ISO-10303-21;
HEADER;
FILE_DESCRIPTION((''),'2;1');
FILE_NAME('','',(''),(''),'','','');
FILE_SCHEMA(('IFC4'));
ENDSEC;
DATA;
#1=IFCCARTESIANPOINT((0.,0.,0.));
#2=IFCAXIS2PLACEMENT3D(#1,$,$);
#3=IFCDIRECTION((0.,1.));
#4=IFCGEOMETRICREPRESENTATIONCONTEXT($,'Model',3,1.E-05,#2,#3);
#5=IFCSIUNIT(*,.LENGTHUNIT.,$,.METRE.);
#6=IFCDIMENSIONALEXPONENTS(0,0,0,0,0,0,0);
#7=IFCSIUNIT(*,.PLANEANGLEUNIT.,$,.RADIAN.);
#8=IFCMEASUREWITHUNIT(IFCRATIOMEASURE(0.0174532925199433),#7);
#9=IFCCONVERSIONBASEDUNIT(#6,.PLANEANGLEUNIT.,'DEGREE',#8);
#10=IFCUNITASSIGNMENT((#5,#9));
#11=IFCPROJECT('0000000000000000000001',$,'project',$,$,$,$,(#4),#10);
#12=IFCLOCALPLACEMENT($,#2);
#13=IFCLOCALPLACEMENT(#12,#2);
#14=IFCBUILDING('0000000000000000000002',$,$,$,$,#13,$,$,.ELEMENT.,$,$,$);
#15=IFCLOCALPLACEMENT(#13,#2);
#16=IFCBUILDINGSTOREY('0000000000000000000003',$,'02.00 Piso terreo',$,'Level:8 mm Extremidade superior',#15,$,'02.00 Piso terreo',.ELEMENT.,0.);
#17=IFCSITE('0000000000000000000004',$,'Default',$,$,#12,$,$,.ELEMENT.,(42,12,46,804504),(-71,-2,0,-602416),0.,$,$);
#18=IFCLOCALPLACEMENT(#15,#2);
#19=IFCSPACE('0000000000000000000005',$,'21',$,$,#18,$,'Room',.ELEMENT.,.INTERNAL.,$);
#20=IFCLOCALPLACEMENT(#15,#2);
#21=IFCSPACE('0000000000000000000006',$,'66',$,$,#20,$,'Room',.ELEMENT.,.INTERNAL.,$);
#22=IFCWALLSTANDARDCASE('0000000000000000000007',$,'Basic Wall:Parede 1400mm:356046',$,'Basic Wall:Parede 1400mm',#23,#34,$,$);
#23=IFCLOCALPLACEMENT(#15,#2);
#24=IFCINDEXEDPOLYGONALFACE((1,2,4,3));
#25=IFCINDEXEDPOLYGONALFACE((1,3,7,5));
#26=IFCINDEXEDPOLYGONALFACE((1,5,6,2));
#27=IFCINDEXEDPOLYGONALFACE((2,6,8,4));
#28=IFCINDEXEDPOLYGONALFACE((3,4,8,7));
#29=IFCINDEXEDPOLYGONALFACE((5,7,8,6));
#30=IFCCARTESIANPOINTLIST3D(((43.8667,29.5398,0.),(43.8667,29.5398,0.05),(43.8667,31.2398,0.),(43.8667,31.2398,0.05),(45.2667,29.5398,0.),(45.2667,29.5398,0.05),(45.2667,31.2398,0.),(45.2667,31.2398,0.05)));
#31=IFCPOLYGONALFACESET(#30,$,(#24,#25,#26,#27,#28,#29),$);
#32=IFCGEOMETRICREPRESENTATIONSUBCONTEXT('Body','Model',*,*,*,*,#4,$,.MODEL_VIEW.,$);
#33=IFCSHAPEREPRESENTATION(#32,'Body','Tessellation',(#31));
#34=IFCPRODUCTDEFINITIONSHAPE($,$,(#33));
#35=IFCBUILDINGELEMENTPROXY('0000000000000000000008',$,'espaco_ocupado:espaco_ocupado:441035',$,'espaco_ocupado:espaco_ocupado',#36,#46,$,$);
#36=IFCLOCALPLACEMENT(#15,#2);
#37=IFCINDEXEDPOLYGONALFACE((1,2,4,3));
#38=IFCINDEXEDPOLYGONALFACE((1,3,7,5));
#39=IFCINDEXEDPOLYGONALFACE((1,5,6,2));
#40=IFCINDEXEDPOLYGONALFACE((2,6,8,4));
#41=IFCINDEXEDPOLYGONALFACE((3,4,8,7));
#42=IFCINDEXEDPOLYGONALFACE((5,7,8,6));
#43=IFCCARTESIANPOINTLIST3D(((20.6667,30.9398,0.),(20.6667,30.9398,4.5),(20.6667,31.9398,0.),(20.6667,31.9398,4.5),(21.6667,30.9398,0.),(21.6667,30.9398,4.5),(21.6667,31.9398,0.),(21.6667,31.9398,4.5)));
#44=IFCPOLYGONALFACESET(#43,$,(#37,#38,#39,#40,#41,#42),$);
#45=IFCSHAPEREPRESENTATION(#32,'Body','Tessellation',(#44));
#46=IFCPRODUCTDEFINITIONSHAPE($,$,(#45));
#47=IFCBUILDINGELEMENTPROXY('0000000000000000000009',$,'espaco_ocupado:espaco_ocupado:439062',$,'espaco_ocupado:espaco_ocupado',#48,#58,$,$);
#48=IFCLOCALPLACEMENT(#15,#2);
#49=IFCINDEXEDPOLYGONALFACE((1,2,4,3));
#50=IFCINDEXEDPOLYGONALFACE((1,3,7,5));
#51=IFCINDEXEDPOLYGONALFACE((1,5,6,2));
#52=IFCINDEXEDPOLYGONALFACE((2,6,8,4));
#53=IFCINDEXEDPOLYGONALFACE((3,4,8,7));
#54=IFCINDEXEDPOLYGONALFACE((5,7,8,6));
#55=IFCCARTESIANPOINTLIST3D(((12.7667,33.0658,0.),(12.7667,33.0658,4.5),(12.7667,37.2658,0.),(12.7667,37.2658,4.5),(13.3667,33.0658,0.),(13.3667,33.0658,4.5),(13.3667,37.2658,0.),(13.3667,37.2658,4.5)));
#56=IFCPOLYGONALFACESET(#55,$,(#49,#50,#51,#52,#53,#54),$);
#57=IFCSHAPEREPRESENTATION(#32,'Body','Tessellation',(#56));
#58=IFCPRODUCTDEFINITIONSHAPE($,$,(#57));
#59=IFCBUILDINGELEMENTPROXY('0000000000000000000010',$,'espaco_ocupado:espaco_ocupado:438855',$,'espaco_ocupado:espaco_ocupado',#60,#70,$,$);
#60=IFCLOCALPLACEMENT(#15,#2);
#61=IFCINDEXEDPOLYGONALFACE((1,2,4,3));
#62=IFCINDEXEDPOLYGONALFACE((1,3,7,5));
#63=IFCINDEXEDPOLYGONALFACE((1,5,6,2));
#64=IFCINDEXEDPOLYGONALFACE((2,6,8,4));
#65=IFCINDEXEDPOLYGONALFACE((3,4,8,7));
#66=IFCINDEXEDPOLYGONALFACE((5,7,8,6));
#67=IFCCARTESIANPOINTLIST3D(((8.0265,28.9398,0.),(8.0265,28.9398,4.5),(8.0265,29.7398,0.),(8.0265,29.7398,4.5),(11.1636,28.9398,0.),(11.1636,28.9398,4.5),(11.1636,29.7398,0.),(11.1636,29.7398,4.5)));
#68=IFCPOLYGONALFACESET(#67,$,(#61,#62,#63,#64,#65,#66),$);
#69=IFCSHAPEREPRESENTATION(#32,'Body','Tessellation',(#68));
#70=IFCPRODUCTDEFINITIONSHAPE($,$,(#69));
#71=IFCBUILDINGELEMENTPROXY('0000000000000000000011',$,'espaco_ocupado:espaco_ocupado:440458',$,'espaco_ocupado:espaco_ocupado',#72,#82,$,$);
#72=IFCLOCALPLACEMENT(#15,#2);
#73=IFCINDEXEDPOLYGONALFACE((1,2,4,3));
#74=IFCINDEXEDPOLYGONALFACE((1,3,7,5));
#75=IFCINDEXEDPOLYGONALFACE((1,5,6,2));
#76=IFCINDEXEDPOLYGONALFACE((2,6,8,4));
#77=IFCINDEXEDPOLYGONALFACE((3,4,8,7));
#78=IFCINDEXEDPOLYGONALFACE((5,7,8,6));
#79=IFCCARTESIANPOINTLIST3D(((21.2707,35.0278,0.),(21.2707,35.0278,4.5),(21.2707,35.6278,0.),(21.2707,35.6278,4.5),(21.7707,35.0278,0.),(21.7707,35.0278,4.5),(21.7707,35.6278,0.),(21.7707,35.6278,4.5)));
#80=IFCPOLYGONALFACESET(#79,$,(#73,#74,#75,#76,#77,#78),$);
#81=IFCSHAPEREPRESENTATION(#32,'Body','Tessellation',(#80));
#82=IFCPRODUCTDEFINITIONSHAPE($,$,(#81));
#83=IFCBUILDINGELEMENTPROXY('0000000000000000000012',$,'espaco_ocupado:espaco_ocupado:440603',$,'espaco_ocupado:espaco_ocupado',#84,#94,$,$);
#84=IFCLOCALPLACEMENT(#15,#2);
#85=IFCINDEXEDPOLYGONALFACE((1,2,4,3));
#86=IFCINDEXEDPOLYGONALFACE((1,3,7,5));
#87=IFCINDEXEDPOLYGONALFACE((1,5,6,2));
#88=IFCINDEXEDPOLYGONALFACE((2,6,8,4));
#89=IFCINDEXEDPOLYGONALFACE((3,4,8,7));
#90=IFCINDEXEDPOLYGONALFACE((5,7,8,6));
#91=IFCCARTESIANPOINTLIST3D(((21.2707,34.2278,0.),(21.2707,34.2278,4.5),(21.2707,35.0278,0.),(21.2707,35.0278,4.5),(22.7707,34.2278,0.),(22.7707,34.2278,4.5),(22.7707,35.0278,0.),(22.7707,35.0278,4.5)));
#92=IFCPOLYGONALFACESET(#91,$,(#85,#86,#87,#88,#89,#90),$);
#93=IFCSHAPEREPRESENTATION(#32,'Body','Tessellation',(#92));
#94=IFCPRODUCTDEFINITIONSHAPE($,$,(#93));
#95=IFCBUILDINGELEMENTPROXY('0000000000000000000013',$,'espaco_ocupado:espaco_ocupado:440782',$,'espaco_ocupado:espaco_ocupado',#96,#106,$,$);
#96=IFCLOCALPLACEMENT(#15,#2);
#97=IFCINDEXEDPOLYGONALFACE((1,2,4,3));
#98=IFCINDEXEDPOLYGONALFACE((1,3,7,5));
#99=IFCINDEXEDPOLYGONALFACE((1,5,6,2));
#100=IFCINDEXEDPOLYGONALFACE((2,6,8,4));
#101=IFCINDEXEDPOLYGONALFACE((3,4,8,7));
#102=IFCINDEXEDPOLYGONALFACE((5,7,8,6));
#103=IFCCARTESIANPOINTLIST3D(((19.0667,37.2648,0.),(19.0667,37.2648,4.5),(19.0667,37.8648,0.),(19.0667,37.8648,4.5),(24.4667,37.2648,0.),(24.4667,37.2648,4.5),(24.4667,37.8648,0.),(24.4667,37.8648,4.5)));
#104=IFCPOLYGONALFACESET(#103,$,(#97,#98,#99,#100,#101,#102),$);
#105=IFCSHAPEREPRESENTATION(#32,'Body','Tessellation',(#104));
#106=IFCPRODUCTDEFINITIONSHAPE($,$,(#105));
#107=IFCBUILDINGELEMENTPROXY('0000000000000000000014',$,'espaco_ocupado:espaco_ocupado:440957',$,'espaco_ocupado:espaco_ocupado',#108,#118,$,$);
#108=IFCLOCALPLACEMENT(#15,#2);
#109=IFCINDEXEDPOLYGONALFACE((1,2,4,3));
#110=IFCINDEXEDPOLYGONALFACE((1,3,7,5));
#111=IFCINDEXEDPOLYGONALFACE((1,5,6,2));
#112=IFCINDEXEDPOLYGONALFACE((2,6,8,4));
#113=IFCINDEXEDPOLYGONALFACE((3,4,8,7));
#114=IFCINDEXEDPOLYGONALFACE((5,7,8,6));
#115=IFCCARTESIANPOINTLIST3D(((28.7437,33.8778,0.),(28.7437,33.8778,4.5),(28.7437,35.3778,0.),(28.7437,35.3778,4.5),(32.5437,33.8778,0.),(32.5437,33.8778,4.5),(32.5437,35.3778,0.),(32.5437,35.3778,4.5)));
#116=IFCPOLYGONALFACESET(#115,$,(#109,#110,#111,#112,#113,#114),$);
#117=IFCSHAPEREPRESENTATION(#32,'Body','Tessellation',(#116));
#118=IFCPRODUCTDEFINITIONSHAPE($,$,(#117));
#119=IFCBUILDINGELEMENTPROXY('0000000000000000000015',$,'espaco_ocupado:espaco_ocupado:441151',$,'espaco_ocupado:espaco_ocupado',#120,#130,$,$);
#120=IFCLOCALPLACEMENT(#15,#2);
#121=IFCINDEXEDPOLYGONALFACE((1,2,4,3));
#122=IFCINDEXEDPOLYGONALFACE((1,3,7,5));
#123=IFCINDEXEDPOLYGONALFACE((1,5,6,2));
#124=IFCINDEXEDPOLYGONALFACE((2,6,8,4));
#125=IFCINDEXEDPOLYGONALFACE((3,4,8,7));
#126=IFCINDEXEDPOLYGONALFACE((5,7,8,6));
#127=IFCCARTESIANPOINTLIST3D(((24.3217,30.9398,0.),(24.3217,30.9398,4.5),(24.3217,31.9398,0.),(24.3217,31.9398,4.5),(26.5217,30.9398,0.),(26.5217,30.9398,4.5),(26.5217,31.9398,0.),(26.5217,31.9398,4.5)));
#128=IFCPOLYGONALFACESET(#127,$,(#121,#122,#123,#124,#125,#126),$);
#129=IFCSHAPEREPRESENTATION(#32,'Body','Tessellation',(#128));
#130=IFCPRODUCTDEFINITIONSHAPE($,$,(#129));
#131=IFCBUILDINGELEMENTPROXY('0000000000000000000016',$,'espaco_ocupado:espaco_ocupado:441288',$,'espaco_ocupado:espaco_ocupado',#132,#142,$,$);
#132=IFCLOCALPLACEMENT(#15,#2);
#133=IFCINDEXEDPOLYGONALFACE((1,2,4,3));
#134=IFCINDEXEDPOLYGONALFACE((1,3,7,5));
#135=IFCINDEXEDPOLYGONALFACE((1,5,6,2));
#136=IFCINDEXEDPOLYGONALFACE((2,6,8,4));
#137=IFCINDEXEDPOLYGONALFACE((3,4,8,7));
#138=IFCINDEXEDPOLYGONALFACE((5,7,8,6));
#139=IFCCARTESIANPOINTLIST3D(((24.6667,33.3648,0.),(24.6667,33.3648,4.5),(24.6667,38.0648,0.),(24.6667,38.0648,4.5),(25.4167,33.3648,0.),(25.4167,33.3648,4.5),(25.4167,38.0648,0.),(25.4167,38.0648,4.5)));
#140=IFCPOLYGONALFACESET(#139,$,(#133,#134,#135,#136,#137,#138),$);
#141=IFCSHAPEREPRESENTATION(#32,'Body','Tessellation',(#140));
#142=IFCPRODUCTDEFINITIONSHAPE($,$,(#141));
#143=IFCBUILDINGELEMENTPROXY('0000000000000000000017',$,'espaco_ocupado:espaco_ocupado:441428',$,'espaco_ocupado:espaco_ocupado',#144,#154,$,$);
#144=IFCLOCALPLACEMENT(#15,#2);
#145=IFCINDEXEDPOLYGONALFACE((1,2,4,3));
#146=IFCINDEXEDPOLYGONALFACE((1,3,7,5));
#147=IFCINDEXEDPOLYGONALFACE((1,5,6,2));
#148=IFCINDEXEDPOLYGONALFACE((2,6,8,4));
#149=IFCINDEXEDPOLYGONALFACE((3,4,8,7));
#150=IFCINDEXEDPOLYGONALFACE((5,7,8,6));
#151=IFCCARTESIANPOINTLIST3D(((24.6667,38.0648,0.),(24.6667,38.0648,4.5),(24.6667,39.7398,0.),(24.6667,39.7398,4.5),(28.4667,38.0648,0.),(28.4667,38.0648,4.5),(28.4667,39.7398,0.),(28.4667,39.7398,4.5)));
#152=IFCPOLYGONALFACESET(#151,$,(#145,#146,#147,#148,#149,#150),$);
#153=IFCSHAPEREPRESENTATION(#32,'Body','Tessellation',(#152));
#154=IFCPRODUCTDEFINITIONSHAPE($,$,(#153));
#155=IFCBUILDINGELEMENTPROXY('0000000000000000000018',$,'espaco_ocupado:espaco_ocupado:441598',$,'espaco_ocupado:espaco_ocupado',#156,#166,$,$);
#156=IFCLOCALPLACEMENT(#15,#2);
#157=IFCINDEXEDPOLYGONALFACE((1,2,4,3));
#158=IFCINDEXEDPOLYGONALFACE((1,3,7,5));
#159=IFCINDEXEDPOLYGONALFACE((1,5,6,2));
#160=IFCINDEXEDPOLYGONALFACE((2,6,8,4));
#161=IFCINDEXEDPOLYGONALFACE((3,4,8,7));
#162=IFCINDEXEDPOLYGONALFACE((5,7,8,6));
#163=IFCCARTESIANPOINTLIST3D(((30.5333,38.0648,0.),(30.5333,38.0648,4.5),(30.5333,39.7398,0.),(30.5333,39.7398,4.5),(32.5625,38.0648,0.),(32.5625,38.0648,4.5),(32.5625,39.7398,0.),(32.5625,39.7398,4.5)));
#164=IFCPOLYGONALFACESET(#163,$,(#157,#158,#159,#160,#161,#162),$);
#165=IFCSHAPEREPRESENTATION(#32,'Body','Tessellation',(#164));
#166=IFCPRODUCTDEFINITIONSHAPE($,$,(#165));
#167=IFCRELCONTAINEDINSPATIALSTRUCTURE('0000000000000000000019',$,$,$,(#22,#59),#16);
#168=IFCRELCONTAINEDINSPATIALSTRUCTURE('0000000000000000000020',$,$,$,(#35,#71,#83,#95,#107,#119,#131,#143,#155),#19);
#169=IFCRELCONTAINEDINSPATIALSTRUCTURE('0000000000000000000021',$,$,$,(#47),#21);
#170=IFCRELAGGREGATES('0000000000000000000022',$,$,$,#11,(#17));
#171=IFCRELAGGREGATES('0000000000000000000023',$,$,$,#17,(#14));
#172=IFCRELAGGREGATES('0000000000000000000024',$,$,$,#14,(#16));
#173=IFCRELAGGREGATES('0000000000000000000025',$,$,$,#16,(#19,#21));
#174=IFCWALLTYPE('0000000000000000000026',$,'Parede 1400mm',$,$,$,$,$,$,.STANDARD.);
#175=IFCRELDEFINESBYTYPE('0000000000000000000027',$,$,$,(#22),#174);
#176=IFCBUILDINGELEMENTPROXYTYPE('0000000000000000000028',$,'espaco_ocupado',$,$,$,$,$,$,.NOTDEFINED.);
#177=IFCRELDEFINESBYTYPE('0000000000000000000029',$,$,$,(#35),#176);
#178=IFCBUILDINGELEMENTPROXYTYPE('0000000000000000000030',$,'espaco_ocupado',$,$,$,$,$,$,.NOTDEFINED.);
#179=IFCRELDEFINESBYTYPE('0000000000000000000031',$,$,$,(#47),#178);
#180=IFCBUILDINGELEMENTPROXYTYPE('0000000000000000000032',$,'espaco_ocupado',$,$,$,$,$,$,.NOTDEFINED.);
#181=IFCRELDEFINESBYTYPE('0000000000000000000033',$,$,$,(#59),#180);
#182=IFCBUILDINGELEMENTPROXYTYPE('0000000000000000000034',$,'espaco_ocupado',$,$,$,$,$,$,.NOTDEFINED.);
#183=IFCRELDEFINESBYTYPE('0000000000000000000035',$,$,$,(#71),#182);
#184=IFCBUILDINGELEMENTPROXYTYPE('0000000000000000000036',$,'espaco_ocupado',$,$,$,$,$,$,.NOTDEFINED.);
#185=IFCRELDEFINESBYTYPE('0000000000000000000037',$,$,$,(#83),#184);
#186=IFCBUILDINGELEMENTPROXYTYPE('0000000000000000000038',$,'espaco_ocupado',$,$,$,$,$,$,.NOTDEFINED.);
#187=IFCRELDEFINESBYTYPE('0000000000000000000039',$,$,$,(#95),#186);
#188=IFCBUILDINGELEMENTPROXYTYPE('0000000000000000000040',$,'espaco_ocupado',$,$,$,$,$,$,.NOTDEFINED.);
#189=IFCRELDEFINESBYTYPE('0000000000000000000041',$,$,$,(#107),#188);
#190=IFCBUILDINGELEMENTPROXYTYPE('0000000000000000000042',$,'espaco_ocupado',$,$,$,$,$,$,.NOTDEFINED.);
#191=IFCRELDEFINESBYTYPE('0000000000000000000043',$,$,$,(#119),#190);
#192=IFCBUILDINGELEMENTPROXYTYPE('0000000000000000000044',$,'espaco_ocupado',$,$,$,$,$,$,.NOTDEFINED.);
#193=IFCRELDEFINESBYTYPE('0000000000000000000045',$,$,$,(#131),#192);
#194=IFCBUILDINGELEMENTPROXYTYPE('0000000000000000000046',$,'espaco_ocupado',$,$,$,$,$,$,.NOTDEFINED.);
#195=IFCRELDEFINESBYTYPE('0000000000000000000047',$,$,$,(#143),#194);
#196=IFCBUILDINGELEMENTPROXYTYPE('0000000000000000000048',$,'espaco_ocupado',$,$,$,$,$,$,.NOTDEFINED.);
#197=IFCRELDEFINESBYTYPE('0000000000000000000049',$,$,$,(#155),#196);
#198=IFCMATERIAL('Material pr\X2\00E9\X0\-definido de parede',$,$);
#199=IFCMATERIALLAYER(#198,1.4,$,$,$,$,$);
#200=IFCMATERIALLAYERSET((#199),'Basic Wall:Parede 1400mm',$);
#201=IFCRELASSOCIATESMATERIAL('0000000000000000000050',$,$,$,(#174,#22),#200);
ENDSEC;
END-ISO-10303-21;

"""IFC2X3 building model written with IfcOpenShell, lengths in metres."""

from ifc_helpers import new_model, entity, si_unit, converted_unit, direction, frame, frame_2d, origin, origin_2d_with_axis, place, context, subcontext, project, spatial, rectangle, extrude, clip, halfspace, source, transform, mapped, material, layer, layer_set, layer_usage, type_object, type_shapes, element, save


model = new_model("IFC2X3")

# Units and contexts
model_context = context("Model", 3, precision=1e-05, world=origin(), true_north=direction((0.0, 1.0)))
body_context = subcontext(model_context, "Body", "Model", "MODEL_VIEW")
ifc_project = project(units=[si_unit("LENGTHUNIT", "METRE"), converted_unit("PLANEANGLEUNIT", "DEGREE", entity("IfcRatioMeasure", 0.0174532925199433), si_unit("PLANEANGLEUNIT", "RADIAN"), dimensions=[0, 0, 0, 0, 0, 0, 0])], contexts=[model_context])

# Site, building, storey
site_placement = place(None, origin())
site = spatial("IfcSite", under=ifc_project, at=site_placement, Name="Default", CompositionType="ELEMENT", RefLatitude=(42, 12, 46, 804504), RefLongitude=(-71, -2, 0, -602416), RefElevation=0.0)
building_placement = place(site_placement, origin())
building = spatial("IfcBuilding", under=site, at=building_placement, CompositionType="ELEMENT")
storey_placement = place(building_placement, origin())
storey = spatial("IfcBuildingStorey", under=building, at=storey_placement, Name="02.00 Piso terreo", ObjectType="Level:8 mm Extremidade superior", LongName="02.00 Piso terreo", CompositionType="ELEMENT", Elevation=0.0)

# Wall
ifc_material = material(Name="Material pré-definido de parede")
ifc_layer = layer(ifc_material, 1.4)
ifc_layer_set = layer_set([ifc_layer], Name="Basic Wall:Parede 1400mm")
ifc_layer_usage = layer_usage(ifc_layer_set, "AXIS2", "POSITIVE", -0.7)
wall_type = type_object("IfcWallType", Name="Parede 1400mm", PredefinedType="STANDARD", material=ifc_layer_set)
wall_placement = place(storey_placement, frame((44.5667, 31.2398, 0.0), z_axis=(0.0, 0.0, 1.0), x_axis=(0.0, -1.0, 0.0)))
element("IfcWallStandardCase", 1, at=wall_placement, inside=storey, type_object=wall_type, material=ifc_layer_usage, Name="Basic Wall:Parede 1400mm:356046", ObjectType="Basic Wall:Parede 1400mm", context=body_context, shape_type="Clipping", body=[
    clip(extrude(rectangle(XDim=1.7, YDim=1.4, at=frame_2d((0.85, 0.0), x_axis=(-1.0, 0.0))), origin(), (0.0, 0.0, 1.0), 0.05), halfspace(frame((0.0, 0.0, -2.85)), True)),
])

# Shared definitions
space_1_placement = place(storey_placement, origin())
space_1 = spatial("IfcSpace", under=storey, at=space_1_placement, Name="21", LongName="Room", CompositionType="ELEMENT", InteriorOrExteriorSpace="INTERNAL")

# Building element proxy
building_element_proxy_type_1 = type_object("IfcBuildingElementProxyType", Name="espaco_ocupado", PredefinedType="NOTDEFINED")
shared_shape_1 = source(origin(), body_context, "Body", "SweptSolid", [
    extrude(rectangle(XDim=1.0, YDim=1.0, at=origin_2d_with_axis()), frame((0.0, 0.0, 0.0), z_axis=(0.0, 0.0, 1.0), x_axis=(-1.0, 0.0, 0.0)), (0.0, 0.0, 1.0), 4.5),
])
type_shapes(building_element_proxy_type_1, [shared_shape_1])
proxy_1_placement = place(space_1_placement, frame((21.1667, 31.4398, 0.0)))
element("IfcBuildingElementProxy", 2, at=proxy_1_placement, inside=space_1, type_object=building_element_proxy_type_1, Name="espaco_ocupado:espaco_ocupado:441035", ObjectType="espaco_ocupado:espaco_ocupado", context=body_context, shape_type="MappedRepresentation", body=[
    mapped(shared_shape_1, transform((0.0, 0.0, 0.0), scale=1.0)),
])

# Shared definitions
space_2_placement = place(storey_placement, origin())
space_2 = spatial("IfcSpace", under=storey, at=space_2_placement, Name="66", LongName="Room", CompositionType="ELEMENT", InteriorOrExteriorSpace="INTERNAL")

# Building element proxies
building_element_proxy_type_2 = type_object("IfcBuildingElementProxyType", Name="espaco_ocupado", PredefinedType="NOTDEFINED")
shared_shape_2 = source(origin(), body_context, "Body", "SweptSolid", [
    extrude(rectangle(XDim=4.2, YDim=0.6, at=origin_2d_with_axis()), frame((0.0, 0.0, 0.0), z_axis=(0.0, 0.0, 1.0), x_axis=(-1.0, 0.0, 0.0)), (0.0, 0.0, 1.0), 4.5),
])
type_shapes(building_element_proxy_type_2, [shared_shape_2])
proxy_2_placement = place(space_2_placement, frame((13.0667, 35.1658, 0.0), z_axis=(0.0, 0.0, 1.0), x_axis=(0.0, -1.0, 0.0)))
element("IfcBuildingElementProxy", 3, at=proxy_2_placement, inside=space_2, type_object=building_element_proxy_type_2, Name="espaco_ocupado:espaco_ocupado:439062", ObjectType="espaco_ocupado:espaco_ocupado", context=body_context, shape_type="MappedRepresentation", body=[
    mapped(shared_shape_2, transform((0.0, 0.0, 0.0), scale=1.0)),
])
building_element_proxy_type_3 = type_object("IfcBuildingElementProxyType", Name="espaco_ocupado", PredefinedType="NOTDEFINED")
shared_shape_3 = source(origin(), body_context, "Body", "SweptSolid", [
    extrude(rectangle(XDim=3.1371, YDim=0.8, at=origin_2d_with_axis()), frame((0.0, 0.0, 0.0), z_axis=(0.0, 0.0, 1.0), x_axis=(-1.0, 0.0, 0.0)), (0.0, 0.0, 1.0), 4.5),
])
type_shapes(building_element_proxy_type_3, [shared_shape_3])
proxy_3_placement = place(storey_placement, frame((9.5951, 29.3398, 0.0)))
element("IfcBuildingElementProxy", 4, at=proxy_3_placement, inside=storey, type_object=building_element_proxy_type_3, Name="espaco_ocupado:espaco_ocupado:438855", ObjectType="espaco_ocupado:espaco_ocupado", context=body_context, shape_type="MappedRepresentation", body=[
    mapped(shared_shape_3, transform((0.0, 0.0, 0.0), scale=1.0)),
])
building_element_proxy_type_4 = type_object("IfcBuildingElementProxyType", Name="espaco_ocupado", PredefinedType="NOTDEFINED")
shared_shape_4 = source(origin(), body_context, "Body", "SweptSolid", [
    extrude(rectangle(XDim=0.5, YDim=0.6, at=origin_2d_with_axis()), frame((0.0, 0.0, 0.0), z_axis=(0.0, 0.0, 1.0), x_axis=(-1.0, 0.0, 0.0)), (0.0, 0.0, 1.0), 4.5),
])
type_shapes(building_element_proxy_type_4, [shared_shape_4])
proxy_4_placement = place(space_1_placement, frame((21.5207, 35.3278, 0.0)))
element("IfcBuildingElementProxy", 5, at=proxy_4_placement, inside=space_1, type_object=building_element_proxy_type_4, Name="espaco_ocupado:espaco_ocupado:440458", ObjectType="espaco_ocupado:espaco_ocupado", context=body_context, shape_type="MappedRepresentation", body=[
    mapped(shared_shape_4, transform((0.0, 0.0, 0.0), scale=1.0)),
])
building_element_proxy_type_5 = type_object("IfcBuildingElementProxyType", Name="espaco_ocupado", PredefinedType="NOTDEFINED")
shared_shape_5 = source(origin(), body_context, "Body", "SweptSolid", [
    extrude(rectangle(XDim=1.5, YDim=0.8, at=origin_2d_with_axis()), frame((0.0, 0.0, 0.0), z_axis=(0.0, 0.0, 1.0), x_axis=(-1.0, 0.0, 0.0)), (0.0, 0.0, 1.0), 4.5),
])
type_shapes(building_element_proxy_type_5, [shared_shape_5])
proxy_5_placement = place(space_1_placement, frame((22.0207, 34.6278, 0.0)))
element("IfcBuildingElementProxy", 6, at=proxy_5_placement, inside=space_1, type_object=building_element_proxy_type_5, Name="espaco_ocupado:espaco_ocupado:440603", ObjectType="espaco_ocupado:espaco_ocupado", context=body_context, shape_type="MappedRepresentation", body=[
    mapped(shared_shape_5, transform((0.0, 0.0, 0.0), scale=1.0)),
])
building_element_proxy_type_6 = type_object("IfcBuildingElementProxyType", Name="espaco_ocupado", PredefinedType="NOTDEFINED")
shared_shape_6 = source(origin(), body_context, "Body", "SweptSolid", [
    extrude(rectangle(XDim=5.4, YDim=0.6, at=origin_2d_with_axis()), frame((0.0, 0.0, 0.0), z_axis=(0.0, 0.0, 1.0), x_axis=(-1.0, 0.0, 0.0)), (0.0, 0.0, 1.0), 4.5),
])
type_shapes(building_element_proxy_type_6, [shared_shape_6])
proxy_6_placement = place(space_1_placement, frame((21.7667, 37.5648, 0.0)))
element("IfcBuildingElementProxy", 7, at=proxy_6_placement, inside=space_1, type_object=building_element_proxy_type_6, Name="espaco_ocupado:espaco_ocupado:440782", ObjectType="espaco_ocupado:espaco_ocupado", context=body_context, shape_type="MappedRepresentation", body=[
    mapped(shared_shape_6, transform((0.0, 0.0, 0.0), scale=1.0)),
])
building_element_proxy_type_7 = type_object("IfcBuildingElementProxyType", Name="espaco_ocupado", PredefinedType="NOTDEFINED")
shared_shape_7 = source(origin(), body_context, "Body", "SweptSolid", [
    extrude(rectangle(XDim=3.8, YDim=1.5, at=origin_2d_with_axis()), frame((0.0, 0.0, 0.0), z_axis=(0.0, 0.0, 1.0), x_axis=(-1.0, 0.0, 0.0)), (0.0, 0.0, 1.0), 4.5),
])
type_shapes(building_element_proxy_type_7, [shared_shape_7])
proxy_7_placement = place(space_1_placement, frame((30.6437, 34.6278, 0.0)))
element("IfcBuildingElementProxy", 8, at=proxy_7_placement, inside=space_1, type_object=building_element_proxy_type_7, Name="espaco_ocupado:espaco_ocupado:440957", ObjectType="espaco_ocupado:espaco_ocupado", context=body_context, shape_type="MappedRepresentation", body=[
    mapped(shared_shape_7, transform((0.0, 0.0, 0.0), scale=1.0)),
])
building_element_proxy_type_8 = type_object("IfcBuildingElementProxyType", Name="espaco_ocupado", PredefinedType="NOTDEFINED")
shared_shape_8 = source(origin(), body_context, "Body", "SweptSolid", [
    extrude(rectangle(XDim=2.2, YDim=1.0, at=origin_2d_with_axis()), frame((0.0, 0.0, 0.0), z_axis=(0.0, 0.0, 1.0), x_axis=(-1.0, 0.0, 0.0)), (0.0, 0.0, 1.0), 4.5),
])
type_shapes(building_element_proxy_type_8, [shared_shape_8])
proxy_8_placement = place(space_1_placement, frame((25.4217, 31.4398, 0.0)))
element("IfcBuildingElementProxy", 9, at=proxy_8_placement, inside=space_1, type_object=building_element_proxy_type_8, Name="espaco_ocupado:espaco_ocupado:441151", ObjectType="espaco_ocupado:espaco_ocupado", context=body_context, shape_type="MappedRepresentation", body=[
    mapped(shared_shape_8, transform((0.0, 0.0, 0.0), scale=1.0)),
])
building_element_proxy_type_9 = type_object("IfcBuildingElementProxyType", Name="espaco_ocupado", PredefinedType="NOTDEFINED")
shared_shape_9 = source(origin(), body_context, "Body", "SweptSolid", [
    extrude(rectangle(XDim=0.75, YDim=4.7, at=origin_2d_with_axis()), frame((0.0, 0.0, 0.0), z_axis=(0.0, 0.0, 1.0), x_axis=(-1.0, 0.0, 0.0)), (0.0, 0.0, 1.0), 4.5),
])
type_shapes(building_element_proxy_type_9, [shared_shape_9])
proxy_9_placement = place(space_1_placement, frame((25.0417, 35.7148, 0.0)))
element("IfcBuildingElementProxy", 10, at=proxy_9_placement, inside=space_1, type_object=building_element_proxy_type_9, Name="espaco_ocupado:espaco_ocupado:441288", ObjectType="espaco_ocupado:espaco_ocupado", context=body_context, shape_type="MappedRepresentation", body=[
    mapped(shared_shape_9, transform((0.0, 0.0, 0.0), scale=1.0)),
])
building_element_proxy_type_10 = type_object("IfcBuildingElementProxyType", Name="espaco_ocupado", PredefinedType="NOTDEFINED")
shared_shape_10 = source(origin(), body_context, "Body", "SweptSolid", [
    extrude(rectangle(XDim=3.8, YDim=1.675, at=origin_2d_with_axis()), frame((0.0, 0.0, 0.0), z_axis=(0.0, 0.0, 1.0), x_axis=(-1.0, 0.0, 0.0)), (0.0, 0.0, 1.0), 4.5),
])
type_shapes(building_element_proxy_type_10, [shared_shape_10])
proxy_10_placement = place(space_1_placement, frame((26.5667, 38.9023, 0.0)))
element("IfcBuildingElementProxy", 11, at=proxy_10_placement, inside=space_1, type_object=building_element_proxy_type_10, Name="espaco_ocupado:espaco_ocupado:441428", ObjectType="espaco_ocupado:espaco_ocupado", context=body_context, shape_type="MappedRepresentation", body=[
    mapped(shared_shape_10, transform((0.0, 0.0, 0.0), scale=1.0)),
])
building_element_proxy_type_11 = type_object("IfcBuildingElementProxyType", Name="espaco_ocupado", PredefinedType="NOTDEFINED")
shared_shape_11 = source(origin(), body_context, "Body", "SweptSolid", [
    extrude(rectangle(XDim=2.0292, YDim=1.675, at=origin_2d_with_axis()), frame((0.0, 0.0, 0.0), z_axis=(0.0, 0.0, 1.0), x_axis=(-1.0, 0.0, 0.0)), (0.0, 0.0, 1.0), 4.5),
])
type_shapes(building_element_proxy_type_11, [shared_shape_11])
proxy_11_placement = place(space_1_placement, frame((31.5479, 38.9023, 0.0)))
element("IfcBuildingElementProxy", 12, at=proxy_11_placement, inside=space_1, type_object=building_element_proxy_type_11, Name="espaco_ocupado:espaco_ocupado:441598", ObjectType="espaco_ocupado:espaco_ocupado", context=body_context, shape_type="MappedRepresentation", body=[
    mapped(shared_shape_11, transform((0.0, 0.0, 0.0), scale=1.0)),
])

save(model, "model.ifc")
